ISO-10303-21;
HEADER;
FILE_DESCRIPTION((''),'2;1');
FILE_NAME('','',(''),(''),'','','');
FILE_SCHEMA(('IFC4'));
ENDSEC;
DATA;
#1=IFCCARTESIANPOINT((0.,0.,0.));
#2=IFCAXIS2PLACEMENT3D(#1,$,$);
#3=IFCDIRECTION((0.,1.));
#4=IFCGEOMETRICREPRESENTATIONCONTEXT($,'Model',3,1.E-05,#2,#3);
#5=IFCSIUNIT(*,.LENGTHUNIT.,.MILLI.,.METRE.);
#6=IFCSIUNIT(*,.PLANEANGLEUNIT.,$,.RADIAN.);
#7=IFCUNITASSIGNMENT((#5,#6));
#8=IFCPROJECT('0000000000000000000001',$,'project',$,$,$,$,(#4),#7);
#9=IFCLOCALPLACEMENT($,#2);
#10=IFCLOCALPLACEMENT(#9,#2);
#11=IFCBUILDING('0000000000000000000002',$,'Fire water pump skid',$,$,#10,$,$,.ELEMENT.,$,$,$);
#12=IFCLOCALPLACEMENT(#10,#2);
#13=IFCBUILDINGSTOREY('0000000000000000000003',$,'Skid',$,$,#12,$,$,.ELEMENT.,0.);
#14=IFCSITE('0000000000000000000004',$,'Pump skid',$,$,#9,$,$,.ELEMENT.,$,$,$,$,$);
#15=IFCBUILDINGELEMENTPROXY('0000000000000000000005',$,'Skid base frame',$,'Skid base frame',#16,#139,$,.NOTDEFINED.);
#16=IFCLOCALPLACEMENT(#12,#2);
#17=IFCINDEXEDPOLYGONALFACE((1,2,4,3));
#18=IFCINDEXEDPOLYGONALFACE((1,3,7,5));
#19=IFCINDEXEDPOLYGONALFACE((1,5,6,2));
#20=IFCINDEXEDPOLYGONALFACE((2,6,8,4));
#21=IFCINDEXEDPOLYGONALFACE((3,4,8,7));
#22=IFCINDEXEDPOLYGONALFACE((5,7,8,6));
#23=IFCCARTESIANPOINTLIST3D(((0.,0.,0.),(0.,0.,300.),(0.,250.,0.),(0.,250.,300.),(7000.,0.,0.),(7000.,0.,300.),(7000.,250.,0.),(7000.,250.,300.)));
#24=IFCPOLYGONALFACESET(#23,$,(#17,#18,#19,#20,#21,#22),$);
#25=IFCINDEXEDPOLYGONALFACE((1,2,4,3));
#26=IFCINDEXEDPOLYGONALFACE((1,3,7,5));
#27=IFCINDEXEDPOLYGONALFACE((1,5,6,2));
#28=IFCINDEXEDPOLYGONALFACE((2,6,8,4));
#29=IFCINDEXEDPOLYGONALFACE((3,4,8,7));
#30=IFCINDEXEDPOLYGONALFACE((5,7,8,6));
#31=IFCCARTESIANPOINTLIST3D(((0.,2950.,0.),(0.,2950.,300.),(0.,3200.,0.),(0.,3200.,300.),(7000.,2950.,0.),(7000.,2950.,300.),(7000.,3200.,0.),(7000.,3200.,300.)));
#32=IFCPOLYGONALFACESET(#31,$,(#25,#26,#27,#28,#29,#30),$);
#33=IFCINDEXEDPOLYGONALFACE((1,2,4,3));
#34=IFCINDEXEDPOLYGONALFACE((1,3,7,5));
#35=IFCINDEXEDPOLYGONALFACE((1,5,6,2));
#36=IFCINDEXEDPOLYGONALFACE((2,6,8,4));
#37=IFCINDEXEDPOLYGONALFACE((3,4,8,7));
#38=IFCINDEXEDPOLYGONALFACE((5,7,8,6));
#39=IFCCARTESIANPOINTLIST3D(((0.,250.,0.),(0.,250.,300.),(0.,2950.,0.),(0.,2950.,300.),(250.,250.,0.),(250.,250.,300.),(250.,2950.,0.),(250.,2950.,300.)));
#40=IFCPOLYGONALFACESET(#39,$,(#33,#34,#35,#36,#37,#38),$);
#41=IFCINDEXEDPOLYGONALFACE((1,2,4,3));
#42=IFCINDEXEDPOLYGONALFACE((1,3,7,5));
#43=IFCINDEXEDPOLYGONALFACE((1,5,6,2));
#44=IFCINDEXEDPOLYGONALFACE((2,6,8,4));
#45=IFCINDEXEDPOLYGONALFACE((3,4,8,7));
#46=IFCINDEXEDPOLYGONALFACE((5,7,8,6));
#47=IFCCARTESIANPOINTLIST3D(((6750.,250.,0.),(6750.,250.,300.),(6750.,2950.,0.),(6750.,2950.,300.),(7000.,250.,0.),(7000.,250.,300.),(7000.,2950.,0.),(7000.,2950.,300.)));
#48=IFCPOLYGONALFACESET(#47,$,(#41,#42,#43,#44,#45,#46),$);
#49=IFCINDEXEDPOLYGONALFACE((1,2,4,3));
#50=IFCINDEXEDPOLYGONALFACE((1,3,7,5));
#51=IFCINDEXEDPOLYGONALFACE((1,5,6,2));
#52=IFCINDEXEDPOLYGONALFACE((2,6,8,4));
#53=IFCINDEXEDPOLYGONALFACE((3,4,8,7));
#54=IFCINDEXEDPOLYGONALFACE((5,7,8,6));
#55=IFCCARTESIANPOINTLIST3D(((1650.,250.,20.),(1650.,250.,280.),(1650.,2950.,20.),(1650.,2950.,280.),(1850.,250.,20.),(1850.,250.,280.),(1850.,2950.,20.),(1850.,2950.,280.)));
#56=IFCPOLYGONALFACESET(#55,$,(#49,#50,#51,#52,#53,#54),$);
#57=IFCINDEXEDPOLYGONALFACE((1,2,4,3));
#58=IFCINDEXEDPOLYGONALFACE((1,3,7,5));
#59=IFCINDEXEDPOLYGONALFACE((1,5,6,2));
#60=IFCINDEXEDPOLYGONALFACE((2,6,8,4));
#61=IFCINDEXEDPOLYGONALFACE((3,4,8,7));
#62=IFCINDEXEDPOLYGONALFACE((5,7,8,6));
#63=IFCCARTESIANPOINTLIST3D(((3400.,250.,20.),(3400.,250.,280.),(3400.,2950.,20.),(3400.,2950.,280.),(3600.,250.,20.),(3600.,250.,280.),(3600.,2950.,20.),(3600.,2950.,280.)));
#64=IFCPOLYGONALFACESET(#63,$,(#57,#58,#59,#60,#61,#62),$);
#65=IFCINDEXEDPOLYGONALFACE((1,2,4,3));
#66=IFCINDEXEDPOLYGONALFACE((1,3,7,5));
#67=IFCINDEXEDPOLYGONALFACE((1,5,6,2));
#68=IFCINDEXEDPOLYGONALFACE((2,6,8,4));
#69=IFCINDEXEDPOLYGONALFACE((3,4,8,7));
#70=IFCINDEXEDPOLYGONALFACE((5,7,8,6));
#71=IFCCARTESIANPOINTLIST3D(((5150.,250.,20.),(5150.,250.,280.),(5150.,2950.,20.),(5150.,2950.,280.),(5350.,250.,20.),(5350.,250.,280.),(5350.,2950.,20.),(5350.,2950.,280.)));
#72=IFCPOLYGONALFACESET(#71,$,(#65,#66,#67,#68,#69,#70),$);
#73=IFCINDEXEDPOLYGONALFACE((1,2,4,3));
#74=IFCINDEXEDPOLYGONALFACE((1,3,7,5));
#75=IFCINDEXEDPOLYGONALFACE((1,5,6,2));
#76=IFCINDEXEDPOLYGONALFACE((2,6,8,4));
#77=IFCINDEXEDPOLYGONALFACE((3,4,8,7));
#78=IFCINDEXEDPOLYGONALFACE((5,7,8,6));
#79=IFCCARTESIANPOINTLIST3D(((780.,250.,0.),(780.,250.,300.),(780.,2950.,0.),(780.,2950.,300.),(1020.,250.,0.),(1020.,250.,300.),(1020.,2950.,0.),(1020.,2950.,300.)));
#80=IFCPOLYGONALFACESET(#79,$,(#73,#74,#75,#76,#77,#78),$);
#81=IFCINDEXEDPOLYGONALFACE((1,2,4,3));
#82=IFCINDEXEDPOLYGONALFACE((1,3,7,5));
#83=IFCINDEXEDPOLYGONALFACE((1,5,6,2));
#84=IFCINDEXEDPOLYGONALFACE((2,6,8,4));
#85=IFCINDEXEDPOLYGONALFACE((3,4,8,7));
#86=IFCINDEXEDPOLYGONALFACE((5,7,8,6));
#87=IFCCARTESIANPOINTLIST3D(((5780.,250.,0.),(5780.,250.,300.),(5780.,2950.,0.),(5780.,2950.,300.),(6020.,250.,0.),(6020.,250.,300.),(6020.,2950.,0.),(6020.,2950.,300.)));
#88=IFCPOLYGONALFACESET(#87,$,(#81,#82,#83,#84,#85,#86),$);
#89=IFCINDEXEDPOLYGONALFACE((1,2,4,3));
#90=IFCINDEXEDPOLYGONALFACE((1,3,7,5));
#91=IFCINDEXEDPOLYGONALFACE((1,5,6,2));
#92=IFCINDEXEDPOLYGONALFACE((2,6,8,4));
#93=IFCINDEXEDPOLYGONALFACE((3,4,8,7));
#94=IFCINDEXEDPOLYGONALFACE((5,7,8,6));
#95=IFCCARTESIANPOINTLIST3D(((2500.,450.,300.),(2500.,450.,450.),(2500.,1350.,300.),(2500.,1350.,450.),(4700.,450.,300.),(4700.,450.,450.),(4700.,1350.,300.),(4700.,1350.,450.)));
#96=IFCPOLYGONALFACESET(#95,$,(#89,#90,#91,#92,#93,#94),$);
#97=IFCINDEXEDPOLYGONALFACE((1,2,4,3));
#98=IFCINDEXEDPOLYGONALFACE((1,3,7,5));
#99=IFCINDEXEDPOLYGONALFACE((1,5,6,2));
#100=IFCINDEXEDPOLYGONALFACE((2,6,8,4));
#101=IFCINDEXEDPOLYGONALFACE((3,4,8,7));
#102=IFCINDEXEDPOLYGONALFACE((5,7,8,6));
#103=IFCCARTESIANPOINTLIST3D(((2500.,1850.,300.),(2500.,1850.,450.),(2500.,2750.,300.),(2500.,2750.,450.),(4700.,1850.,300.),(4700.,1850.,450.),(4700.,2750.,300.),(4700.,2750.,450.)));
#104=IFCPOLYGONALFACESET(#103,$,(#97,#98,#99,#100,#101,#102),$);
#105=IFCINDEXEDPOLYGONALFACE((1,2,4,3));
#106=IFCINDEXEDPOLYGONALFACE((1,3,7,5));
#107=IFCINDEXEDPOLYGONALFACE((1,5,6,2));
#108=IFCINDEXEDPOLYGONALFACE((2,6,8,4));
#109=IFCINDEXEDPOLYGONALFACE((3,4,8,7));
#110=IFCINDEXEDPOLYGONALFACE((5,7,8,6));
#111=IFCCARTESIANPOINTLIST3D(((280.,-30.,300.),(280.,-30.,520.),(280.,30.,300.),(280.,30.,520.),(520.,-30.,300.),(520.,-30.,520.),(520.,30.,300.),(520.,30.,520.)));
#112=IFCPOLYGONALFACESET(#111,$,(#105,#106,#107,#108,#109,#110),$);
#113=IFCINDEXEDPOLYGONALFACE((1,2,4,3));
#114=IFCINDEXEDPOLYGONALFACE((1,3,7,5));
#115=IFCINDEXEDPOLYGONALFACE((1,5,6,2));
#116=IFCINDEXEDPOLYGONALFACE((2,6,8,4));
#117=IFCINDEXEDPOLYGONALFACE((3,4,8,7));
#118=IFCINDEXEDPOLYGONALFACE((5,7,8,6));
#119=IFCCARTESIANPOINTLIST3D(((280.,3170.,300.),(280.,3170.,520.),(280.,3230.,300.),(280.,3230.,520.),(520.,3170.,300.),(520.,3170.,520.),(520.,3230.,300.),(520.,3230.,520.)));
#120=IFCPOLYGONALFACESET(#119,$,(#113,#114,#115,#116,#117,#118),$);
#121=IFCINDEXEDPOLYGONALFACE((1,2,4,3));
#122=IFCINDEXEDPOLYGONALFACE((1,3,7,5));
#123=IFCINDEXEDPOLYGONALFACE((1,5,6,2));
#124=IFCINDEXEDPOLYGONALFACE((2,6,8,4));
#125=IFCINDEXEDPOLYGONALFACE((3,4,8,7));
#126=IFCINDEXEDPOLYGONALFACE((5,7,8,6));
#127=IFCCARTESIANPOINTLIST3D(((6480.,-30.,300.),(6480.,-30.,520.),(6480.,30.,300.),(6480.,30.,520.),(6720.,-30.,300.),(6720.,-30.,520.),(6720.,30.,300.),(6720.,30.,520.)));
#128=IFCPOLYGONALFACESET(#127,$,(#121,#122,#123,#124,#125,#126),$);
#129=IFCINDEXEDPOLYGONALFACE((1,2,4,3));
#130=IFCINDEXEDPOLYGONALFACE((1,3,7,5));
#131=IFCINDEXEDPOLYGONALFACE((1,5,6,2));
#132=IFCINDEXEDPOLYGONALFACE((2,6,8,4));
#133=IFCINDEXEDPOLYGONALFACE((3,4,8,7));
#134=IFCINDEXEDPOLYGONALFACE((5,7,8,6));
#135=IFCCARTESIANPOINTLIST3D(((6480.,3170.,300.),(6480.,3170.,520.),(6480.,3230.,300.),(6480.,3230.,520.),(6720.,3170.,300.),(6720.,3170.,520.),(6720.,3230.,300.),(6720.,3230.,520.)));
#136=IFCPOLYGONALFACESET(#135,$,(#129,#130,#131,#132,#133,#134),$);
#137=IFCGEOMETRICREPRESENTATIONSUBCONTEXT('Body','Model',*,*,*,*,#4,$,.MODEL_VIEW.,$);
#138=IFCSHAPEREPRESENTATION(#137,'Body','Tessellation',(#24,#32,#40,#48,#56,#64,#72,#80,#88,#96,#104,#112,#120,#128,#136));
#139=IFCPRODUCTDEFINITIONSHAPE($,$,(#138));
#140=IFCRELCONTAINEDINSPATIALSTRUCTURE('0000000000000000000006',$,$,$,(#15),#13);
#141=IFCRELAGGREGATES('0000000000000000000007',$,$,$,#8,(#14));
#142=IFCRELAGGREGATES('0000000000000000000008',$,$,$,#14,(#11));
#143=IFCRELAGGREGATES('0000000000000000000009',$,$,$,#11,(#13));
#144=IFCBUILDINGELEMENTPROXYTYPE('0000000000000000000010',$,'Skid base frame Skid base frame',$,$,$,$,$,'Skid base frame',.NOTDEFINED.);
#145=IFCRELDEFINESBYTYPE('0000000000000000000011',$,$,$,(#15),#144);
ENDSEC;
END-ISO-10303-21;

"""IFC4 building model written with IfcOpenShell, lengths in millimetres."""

from ifc_helpers import new_model, si_unit, direction, frame, origin, origin_with_axes, place, context, subcontext, project, spatial, polyline, outline, extrude, source, transform, mapped, type_object, type_shapes, element, save


model = new_model("IFC4")

# Units and contexts
model_context = context("Model", 3, precision=1e-05, world=origin(), true_north=direction((0.0, 1.0)))
body_context = subcontext(model_context, "Body", "Model", "MODEL_VIEW")
ifc_project = project(units=[si_unit("LENGTHUNIT", "METRE", prefix="MILLI"), si_unit("PLANEANGLEUNIT", "RADIAN")], contexts=[model_context])

# Site, building, storey
site_placement = place(None, origin())
site = spatial("IfcSite", under=ifc_project, at=site_placement, Name="Pump skid", CompositionType="ELEMENT")
building_placement = place(site_placement, origin())
building = spatial("IfcBuilding", under=site, at=building_placement, Name="Fire water pump skid", CompositionType="ELEMENT")
storey_placement = place(building_placement, origin())
storey = spatial("IfcBuildingStorey", under=building, at=storey_placement, Name="Skid", CompositionType="ELEMENT", Elevation=0.0)

# Building element proxy
building_element_proxy_type = type_object("IfcBuildingElementProxyType", Name="Skid base frame Skid base frame", ElementType="Skid base frame", PredefinedType="NOTDEFINED")
shared_shape = source(origin(), body_context, "Body", "SweptSolid", [
    extrude(outline(polyline([(0.0, 0.0), (7000.0, 0.0), (7000.0, 250.0), (0.0, 250.0), (0.0, 0.0)])), origin(), (0.0, 0.0, 1.0), 300.0),
    extrude(outline(polyline([(0.0, 2950.0), (7000.0, 2950.0), (7000.0, 3200.0), (0.0, 3200.0), (0.0, 2950.0)])), origin(), (0.0, 0.0, 1.0), 300.0),
    extrude(outline(polyline([(0.0, 250.0), (250.0, 250.0), (250.0, 2950.0), (0.0, 2950.0), (0.0, 250.0)])), origin(), (0.0, 0.0, 1.0), 300.0),
    extrude(outline(polyline([(6750.0, 250.0), (7000.0, 250.0), (7000.0, 2950.0), (6750.0, 2950.0), (6750.0, 250.0)])), origin(), (0.0, 0.0, 1.0), 300.0),
    extrude(outline(polyline([(1650.0, 250.0), (1850.0, 250.0), (1850.0, 2950.0), (1650.0, 2950.0), (1650.0, 250.0)])), frame((0.0, 0.0, 20.0)), (0.0, 0.0, 1.0), 260.0),
    extrude(outline(polyline([(3400.0, 250.0), (3600.0, 250.0), (3600.0, 2950.0), (3400.0, 2950.0), (3400.0, 250.0)])), frame((0.0, 0.0, 20.0)), (0.0, 0.0, 1.0), 260.0),
    extrude(outline(polyline([(5150.0, 250.0), (5350.0, 250.0), (5350.0, 2950.0), (5150.0, 2950.0), (5150.0, 250.0)])), frame((0.0, 0.0, 20.0)), (0.0, 0.0, 1.0), 260.0),
    extrude(outline(polyline([(780.0, 250.0), (1020.0, 250.0), (1020.0, 2950.0), (780.0, 2950.0), (780.0, 250.0)])), origin(), (0.0, 0.0, 1.0), 300.0),
    extrude(outline(polyline([(5780.0, 250.0), (6020.0, 250.0), (6020.0, 2950.0), (5780.0, 2950.0), (5780.0, 250.0)])), origin(), (0.0, 0.0, 1.0), 300.0),
    extrude(outline(polyline([(2500.0, 450.0), (4700.0, 450.0), (4700.0, 1350.0), (2500.0, 1350.0), (2500.0, 450.0)])), frame((0.0, 0.0, 300.0)), (0.0, 0.0, 1.0), 150.0),
    extrude(outline(polyline([(2500.0, 1850.0), (4700.0, 1850.0), (4700.0, 2750.0), (2500.0, 2750.0), (2500.0, 1850.0)])), frame((0.0, 0.0, 300.0)), (0.0, 0.0, 1.0), 150.0),
    extrude(outline(polyline([(280.0, -30.0), (520.0, -30.0), (520.0, 30.0), (280.0, 30.0), (280.0, -30.0)])), frame((0.0, 0.0, 300.0)), (0.0, 0.0, 1.0), 220.0),
    extrude(outline(polyline([(280.0, 3170.0), (520.0, 3170.0), (520.0, 3230.0), (280.0, 3230.0), (280.0, 3170.0)])), frame((0.0, 0.0, 300.0)), (0.0, 0.0, 1.0), 220.0),
    extrude(outline(polyline([(6480.0, -30.0), (6720.0, -30.0), (6720.0, 30.0), (6480.0, 30.0), (6480.0, -30.0)])), frame((0.0, 0.0, 300.0)), (0.0, 0.0, 1.0), 220.0),
    extrude(outline(polyline([(6480.0, 3170.0), (6720.0, 3170.0), (6720.0, 3230.0), (6480.0, 3230.0), (6480.0, 3170.0)])), frame((0.0, 0.0, 300.0)), (0.0, 0.0, 1.0), 220.0),
])
type_shapes(building_element_proxy_type, [shared_shape])
proxy_placement = place(storey_placement, origin_with_axes())
element("IfcBuildingElementProxy", 1, at=proxy_placement, inside=storey, type_object=building_element_proxy_type, Name="Skid base frame", ObjectType="Skid base frame", PredefinedType="NOTDEFINED", context=body_context, shape_type="MappedRepresentation", body=[
    mapped(shared_shape, transform((0.0, 0.0, 0.0))),
])

save(model, "model.ifc")
